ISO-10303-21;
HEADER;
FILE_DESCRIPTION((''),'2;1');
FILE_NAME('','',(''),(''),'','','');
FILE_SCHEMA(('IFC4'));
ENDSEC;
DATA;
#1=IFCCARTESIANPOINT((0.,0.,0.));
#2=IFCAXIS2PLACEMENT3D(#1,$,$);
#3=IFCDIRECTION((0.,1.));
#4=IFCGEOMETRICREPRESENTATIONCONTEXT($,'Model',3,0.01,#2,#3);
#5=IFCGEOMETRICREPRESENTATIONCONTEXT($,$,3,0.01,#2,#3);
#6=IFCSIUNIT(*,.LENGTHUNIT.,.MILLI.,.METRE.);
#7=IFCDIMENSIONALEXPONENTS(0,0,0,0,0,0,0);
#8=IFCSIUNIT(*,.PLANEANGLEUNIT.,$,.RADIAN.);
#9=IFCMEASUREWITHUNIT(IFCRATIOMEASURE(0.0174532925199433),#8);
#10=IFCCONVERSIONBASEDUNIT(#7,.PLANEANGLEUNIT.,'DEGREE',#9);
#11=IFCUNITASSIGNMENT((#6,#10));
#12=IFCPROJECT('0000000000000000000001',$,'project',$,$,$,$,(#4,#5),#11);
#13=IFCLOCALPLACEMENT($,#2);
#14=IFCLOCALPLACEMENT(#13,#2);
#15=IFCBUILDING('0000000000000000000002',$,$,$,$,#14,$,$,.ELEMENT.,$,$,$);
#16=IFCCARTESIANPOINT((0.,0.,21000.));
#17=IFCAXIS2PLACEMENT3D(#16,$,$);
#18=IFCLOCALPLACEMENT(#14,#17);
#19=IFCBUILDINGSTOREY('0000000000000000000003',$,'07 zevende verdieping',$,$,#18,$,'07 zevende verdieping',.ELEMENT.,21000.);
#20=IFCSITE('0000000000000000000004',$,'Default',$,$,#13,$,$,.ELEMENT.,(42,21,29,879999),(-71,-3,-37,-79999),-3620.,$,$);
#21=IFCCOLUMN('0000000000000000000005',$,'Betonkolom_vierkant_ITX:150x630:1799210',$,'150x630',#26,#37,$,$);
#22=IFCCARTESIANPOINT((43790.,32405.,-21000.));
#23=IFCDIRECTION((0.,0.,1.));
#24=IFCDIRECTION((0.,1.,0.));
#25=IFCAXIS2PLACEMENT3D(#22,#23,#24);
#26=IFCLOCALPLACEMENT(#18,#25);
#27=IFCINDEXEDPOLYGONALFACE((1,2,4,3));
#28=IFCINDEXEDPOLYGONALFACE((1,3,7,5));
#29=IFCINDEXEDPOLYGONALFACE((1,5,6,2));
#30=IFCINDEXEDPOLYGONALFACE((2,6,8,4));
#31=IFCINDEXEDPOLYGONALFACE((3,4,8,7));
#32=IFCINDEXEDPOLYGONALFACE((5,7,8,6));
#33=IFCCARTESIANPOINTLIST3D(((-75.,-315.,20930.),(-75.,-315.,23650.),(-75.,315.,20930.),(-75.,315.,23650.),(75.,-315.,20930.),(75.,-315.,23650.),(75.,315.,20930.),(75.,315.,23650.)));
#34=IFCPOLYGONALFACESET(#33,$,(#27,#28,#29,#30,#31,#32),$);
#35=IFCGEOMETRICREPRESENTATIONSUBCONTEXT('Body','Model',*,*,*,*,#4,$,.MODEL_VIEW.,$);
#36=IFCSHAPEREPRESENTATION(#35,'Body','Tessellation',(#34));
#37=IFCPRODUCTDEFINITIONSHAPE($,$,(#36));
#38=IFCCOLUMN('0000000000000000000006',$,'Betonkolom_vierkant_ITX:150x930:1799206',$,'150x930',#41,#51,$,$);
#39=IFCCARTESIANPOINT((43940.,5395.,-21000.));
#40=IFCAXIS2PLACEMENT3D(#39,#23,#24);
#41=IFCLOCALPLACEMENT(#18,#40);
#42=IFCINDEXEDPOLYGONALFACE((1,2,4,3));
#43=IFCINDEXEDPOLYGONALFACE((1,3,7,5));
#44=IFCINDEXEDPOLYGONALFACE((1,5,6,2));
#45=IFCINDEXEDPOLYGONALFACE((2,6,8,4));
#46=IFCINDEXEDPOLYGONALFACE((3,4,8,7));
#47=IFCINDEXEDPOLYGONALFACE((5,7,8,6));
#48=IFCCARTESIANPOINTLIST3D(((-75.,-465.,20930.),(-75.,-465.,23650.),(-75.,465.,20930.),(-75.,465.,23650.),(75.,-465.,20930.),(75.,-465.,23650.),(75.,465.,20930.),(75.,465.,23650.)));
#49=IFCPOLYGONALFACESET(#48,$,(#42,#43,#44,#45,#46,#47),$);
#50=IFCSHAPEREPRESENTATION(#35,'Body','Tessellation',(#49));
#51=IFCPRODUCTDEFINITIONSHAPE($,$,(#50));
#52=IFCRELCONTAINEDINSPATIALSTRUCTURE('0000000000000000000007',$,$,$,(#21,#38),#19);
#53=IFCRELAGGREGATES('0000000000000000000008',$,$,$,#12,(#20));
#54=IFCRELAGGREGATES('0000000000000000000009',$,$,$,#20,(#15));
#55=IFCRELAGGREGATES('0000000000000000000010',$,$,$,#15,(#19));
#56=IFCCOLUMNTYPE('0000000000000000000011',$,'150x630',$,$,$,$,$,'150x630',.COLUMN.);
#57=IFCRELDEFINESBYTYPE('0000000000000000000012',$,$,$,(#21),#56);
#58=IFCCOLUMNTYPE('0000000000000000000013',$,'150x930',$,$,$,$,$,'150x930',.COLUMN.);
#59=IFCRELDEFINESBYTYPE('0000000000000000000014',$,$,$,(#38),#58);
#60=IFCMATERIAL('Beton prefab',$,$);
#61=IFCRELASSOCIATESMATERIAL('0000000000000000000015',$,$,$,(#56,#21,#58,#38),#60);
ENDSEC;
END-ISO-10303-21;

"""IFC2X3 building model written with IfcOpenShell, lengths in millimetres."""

from ifc_helpers import new_model, entity, si_unit, converted_unit, direction, frame, origin, origin_2d_with_axis, place, context, subcontext, project, spatial, rectangle, extrude, source, transform, mapped, material, type_object, type_shapes, element, save


model = new_model("IFC2X3")

# Units and contexts
model_context = context("Model", 3, precision=0.01, world=origin(), true_north=direction((0.0, 1.0)))
context_of_model = context(None, 3, precision=0.01, world=origin(), true_north=direction((0.0, 1.0)))
body_context = subcontext(model_context, "Body", "Model", "MODEL_VIEW")
ifc_project = project(units=[si_unit("LENGTHUNIT", "METRE", prefix="MILLI"), converted_unit("PLANEANGLEUNIT", "DEGREE", entity("IfcRatioMeasure", 0.0174532925199433), si_unit("PLANEANGLEUNIT", "RADIAN"), dimensions=[0, 0, 0, 0, 0, 0, 0])], contexts=[model_context, context_of_model])

# Site, building, storey
site_placement = place(None, origin())
site = spatial("IfcSite", under=ifc_project, at=site_placement, Name="Default", CompositionType="ELEMENT", RefLatitude=(42, 21, 29, 879999), RefLongitude=(-71, -3, -37, -79999), RefElevation=-3620.0)
building_placement = place(site_placement, origin())
building = spatial("IfcBuilding", under=site, at=building_placement, CompositionType="ELEMENT")
storey_placement = place(building_placement, frame((0.0, 0.0, 21000.0)))
storey = spatial("IfcBuildingStorey", under=building, at=storey_placement, Name="07 zevende verdieping", LongName="07 zevende verdieping", CompositionType="ELEMENT", Elevation=21000.0)

# Columns
ifc_material_1 = material(Name="Beton prefab")
column_type_1 = type_object("IfcColumnType", Name="150x630", ElementType="150x630", PredefinedType="COLUMN", material=ifc_material_1)
shared_shape_1 = source(origin(), body_context, "Body", "SweptSolid", [
    extrude(rectangle(XDim=630.0, YDim=150.0, at=origin_2d_with_axis()), frame((0.0, 0.0, 20930.0), z_axis=(0.0, 0.0, 1.0), x_axis=(0.0, -1.0, 0.0)), (0.0, 0.0, 1.0), 2720.0),
])
type_shapes(column_type_1, [shared_shape_1])
column_1_placement = place(storey_placement, frame((43790.0, 32405.0, -21000.0), z_axis=(0.0, 0.0, 1.0), x_axis=(0.0, 1.0, 0.0)))
element("IfcColumn", 1, at=column_1_placement, inside=storey, type_object=column_type_1, material=ifc_material_1, Name="Betonkolom_vierkant_ITX:150x630:1799210", ObjectType="150x630", context=body_context, shape_type="MappedRepresentation", body=[
    mapped(shared_shape_1, transform((0.0, 0.0, 0.0), scale=1.0)),
])
column_type_2 = type_object("IfcColumnType", Name="150x930", ElementType="150x930", PredefinedType="COLUMN", material=ifc_material_1)
shared_shape_2 = source(origin(), body_context, "Body", "SweptSolid", [
    extrude(rectangle(XDim=930.0, YDim=150.0, at=origin_2d_with_axis()), frame((0.0, 0.0, 20930.0), z_axis=(0.0, 0.0, 1.0), x_axis=(0.0, -1.0, 0.0)), (0.0, 0.0, 1.0), 2720.0),
])
type_shapes(column_type_2, [shared_shape_2])
column_2_placement = place(storey_placement, frame((43940.0, 5395.0, -21000.0), z_axis=(0.0, 0.0, 1.0), x_axis=(0.0, 1.0, 0.0)))
element("IfcColumn", 2, at=column_2_placement, inside=storey, type_object=column_type_2, material=ifc_material_1, Name="Betonkolom_vierkant_ITX:150x930:1799206", ObjectType="150x930", context=body_context, shape_type="MappedRepresentation", body=[
    mapped(shared_shape_2, transform((0.0, 0.0, 0.0), scale=1.0)),
])

save(model, "model.ifc")
